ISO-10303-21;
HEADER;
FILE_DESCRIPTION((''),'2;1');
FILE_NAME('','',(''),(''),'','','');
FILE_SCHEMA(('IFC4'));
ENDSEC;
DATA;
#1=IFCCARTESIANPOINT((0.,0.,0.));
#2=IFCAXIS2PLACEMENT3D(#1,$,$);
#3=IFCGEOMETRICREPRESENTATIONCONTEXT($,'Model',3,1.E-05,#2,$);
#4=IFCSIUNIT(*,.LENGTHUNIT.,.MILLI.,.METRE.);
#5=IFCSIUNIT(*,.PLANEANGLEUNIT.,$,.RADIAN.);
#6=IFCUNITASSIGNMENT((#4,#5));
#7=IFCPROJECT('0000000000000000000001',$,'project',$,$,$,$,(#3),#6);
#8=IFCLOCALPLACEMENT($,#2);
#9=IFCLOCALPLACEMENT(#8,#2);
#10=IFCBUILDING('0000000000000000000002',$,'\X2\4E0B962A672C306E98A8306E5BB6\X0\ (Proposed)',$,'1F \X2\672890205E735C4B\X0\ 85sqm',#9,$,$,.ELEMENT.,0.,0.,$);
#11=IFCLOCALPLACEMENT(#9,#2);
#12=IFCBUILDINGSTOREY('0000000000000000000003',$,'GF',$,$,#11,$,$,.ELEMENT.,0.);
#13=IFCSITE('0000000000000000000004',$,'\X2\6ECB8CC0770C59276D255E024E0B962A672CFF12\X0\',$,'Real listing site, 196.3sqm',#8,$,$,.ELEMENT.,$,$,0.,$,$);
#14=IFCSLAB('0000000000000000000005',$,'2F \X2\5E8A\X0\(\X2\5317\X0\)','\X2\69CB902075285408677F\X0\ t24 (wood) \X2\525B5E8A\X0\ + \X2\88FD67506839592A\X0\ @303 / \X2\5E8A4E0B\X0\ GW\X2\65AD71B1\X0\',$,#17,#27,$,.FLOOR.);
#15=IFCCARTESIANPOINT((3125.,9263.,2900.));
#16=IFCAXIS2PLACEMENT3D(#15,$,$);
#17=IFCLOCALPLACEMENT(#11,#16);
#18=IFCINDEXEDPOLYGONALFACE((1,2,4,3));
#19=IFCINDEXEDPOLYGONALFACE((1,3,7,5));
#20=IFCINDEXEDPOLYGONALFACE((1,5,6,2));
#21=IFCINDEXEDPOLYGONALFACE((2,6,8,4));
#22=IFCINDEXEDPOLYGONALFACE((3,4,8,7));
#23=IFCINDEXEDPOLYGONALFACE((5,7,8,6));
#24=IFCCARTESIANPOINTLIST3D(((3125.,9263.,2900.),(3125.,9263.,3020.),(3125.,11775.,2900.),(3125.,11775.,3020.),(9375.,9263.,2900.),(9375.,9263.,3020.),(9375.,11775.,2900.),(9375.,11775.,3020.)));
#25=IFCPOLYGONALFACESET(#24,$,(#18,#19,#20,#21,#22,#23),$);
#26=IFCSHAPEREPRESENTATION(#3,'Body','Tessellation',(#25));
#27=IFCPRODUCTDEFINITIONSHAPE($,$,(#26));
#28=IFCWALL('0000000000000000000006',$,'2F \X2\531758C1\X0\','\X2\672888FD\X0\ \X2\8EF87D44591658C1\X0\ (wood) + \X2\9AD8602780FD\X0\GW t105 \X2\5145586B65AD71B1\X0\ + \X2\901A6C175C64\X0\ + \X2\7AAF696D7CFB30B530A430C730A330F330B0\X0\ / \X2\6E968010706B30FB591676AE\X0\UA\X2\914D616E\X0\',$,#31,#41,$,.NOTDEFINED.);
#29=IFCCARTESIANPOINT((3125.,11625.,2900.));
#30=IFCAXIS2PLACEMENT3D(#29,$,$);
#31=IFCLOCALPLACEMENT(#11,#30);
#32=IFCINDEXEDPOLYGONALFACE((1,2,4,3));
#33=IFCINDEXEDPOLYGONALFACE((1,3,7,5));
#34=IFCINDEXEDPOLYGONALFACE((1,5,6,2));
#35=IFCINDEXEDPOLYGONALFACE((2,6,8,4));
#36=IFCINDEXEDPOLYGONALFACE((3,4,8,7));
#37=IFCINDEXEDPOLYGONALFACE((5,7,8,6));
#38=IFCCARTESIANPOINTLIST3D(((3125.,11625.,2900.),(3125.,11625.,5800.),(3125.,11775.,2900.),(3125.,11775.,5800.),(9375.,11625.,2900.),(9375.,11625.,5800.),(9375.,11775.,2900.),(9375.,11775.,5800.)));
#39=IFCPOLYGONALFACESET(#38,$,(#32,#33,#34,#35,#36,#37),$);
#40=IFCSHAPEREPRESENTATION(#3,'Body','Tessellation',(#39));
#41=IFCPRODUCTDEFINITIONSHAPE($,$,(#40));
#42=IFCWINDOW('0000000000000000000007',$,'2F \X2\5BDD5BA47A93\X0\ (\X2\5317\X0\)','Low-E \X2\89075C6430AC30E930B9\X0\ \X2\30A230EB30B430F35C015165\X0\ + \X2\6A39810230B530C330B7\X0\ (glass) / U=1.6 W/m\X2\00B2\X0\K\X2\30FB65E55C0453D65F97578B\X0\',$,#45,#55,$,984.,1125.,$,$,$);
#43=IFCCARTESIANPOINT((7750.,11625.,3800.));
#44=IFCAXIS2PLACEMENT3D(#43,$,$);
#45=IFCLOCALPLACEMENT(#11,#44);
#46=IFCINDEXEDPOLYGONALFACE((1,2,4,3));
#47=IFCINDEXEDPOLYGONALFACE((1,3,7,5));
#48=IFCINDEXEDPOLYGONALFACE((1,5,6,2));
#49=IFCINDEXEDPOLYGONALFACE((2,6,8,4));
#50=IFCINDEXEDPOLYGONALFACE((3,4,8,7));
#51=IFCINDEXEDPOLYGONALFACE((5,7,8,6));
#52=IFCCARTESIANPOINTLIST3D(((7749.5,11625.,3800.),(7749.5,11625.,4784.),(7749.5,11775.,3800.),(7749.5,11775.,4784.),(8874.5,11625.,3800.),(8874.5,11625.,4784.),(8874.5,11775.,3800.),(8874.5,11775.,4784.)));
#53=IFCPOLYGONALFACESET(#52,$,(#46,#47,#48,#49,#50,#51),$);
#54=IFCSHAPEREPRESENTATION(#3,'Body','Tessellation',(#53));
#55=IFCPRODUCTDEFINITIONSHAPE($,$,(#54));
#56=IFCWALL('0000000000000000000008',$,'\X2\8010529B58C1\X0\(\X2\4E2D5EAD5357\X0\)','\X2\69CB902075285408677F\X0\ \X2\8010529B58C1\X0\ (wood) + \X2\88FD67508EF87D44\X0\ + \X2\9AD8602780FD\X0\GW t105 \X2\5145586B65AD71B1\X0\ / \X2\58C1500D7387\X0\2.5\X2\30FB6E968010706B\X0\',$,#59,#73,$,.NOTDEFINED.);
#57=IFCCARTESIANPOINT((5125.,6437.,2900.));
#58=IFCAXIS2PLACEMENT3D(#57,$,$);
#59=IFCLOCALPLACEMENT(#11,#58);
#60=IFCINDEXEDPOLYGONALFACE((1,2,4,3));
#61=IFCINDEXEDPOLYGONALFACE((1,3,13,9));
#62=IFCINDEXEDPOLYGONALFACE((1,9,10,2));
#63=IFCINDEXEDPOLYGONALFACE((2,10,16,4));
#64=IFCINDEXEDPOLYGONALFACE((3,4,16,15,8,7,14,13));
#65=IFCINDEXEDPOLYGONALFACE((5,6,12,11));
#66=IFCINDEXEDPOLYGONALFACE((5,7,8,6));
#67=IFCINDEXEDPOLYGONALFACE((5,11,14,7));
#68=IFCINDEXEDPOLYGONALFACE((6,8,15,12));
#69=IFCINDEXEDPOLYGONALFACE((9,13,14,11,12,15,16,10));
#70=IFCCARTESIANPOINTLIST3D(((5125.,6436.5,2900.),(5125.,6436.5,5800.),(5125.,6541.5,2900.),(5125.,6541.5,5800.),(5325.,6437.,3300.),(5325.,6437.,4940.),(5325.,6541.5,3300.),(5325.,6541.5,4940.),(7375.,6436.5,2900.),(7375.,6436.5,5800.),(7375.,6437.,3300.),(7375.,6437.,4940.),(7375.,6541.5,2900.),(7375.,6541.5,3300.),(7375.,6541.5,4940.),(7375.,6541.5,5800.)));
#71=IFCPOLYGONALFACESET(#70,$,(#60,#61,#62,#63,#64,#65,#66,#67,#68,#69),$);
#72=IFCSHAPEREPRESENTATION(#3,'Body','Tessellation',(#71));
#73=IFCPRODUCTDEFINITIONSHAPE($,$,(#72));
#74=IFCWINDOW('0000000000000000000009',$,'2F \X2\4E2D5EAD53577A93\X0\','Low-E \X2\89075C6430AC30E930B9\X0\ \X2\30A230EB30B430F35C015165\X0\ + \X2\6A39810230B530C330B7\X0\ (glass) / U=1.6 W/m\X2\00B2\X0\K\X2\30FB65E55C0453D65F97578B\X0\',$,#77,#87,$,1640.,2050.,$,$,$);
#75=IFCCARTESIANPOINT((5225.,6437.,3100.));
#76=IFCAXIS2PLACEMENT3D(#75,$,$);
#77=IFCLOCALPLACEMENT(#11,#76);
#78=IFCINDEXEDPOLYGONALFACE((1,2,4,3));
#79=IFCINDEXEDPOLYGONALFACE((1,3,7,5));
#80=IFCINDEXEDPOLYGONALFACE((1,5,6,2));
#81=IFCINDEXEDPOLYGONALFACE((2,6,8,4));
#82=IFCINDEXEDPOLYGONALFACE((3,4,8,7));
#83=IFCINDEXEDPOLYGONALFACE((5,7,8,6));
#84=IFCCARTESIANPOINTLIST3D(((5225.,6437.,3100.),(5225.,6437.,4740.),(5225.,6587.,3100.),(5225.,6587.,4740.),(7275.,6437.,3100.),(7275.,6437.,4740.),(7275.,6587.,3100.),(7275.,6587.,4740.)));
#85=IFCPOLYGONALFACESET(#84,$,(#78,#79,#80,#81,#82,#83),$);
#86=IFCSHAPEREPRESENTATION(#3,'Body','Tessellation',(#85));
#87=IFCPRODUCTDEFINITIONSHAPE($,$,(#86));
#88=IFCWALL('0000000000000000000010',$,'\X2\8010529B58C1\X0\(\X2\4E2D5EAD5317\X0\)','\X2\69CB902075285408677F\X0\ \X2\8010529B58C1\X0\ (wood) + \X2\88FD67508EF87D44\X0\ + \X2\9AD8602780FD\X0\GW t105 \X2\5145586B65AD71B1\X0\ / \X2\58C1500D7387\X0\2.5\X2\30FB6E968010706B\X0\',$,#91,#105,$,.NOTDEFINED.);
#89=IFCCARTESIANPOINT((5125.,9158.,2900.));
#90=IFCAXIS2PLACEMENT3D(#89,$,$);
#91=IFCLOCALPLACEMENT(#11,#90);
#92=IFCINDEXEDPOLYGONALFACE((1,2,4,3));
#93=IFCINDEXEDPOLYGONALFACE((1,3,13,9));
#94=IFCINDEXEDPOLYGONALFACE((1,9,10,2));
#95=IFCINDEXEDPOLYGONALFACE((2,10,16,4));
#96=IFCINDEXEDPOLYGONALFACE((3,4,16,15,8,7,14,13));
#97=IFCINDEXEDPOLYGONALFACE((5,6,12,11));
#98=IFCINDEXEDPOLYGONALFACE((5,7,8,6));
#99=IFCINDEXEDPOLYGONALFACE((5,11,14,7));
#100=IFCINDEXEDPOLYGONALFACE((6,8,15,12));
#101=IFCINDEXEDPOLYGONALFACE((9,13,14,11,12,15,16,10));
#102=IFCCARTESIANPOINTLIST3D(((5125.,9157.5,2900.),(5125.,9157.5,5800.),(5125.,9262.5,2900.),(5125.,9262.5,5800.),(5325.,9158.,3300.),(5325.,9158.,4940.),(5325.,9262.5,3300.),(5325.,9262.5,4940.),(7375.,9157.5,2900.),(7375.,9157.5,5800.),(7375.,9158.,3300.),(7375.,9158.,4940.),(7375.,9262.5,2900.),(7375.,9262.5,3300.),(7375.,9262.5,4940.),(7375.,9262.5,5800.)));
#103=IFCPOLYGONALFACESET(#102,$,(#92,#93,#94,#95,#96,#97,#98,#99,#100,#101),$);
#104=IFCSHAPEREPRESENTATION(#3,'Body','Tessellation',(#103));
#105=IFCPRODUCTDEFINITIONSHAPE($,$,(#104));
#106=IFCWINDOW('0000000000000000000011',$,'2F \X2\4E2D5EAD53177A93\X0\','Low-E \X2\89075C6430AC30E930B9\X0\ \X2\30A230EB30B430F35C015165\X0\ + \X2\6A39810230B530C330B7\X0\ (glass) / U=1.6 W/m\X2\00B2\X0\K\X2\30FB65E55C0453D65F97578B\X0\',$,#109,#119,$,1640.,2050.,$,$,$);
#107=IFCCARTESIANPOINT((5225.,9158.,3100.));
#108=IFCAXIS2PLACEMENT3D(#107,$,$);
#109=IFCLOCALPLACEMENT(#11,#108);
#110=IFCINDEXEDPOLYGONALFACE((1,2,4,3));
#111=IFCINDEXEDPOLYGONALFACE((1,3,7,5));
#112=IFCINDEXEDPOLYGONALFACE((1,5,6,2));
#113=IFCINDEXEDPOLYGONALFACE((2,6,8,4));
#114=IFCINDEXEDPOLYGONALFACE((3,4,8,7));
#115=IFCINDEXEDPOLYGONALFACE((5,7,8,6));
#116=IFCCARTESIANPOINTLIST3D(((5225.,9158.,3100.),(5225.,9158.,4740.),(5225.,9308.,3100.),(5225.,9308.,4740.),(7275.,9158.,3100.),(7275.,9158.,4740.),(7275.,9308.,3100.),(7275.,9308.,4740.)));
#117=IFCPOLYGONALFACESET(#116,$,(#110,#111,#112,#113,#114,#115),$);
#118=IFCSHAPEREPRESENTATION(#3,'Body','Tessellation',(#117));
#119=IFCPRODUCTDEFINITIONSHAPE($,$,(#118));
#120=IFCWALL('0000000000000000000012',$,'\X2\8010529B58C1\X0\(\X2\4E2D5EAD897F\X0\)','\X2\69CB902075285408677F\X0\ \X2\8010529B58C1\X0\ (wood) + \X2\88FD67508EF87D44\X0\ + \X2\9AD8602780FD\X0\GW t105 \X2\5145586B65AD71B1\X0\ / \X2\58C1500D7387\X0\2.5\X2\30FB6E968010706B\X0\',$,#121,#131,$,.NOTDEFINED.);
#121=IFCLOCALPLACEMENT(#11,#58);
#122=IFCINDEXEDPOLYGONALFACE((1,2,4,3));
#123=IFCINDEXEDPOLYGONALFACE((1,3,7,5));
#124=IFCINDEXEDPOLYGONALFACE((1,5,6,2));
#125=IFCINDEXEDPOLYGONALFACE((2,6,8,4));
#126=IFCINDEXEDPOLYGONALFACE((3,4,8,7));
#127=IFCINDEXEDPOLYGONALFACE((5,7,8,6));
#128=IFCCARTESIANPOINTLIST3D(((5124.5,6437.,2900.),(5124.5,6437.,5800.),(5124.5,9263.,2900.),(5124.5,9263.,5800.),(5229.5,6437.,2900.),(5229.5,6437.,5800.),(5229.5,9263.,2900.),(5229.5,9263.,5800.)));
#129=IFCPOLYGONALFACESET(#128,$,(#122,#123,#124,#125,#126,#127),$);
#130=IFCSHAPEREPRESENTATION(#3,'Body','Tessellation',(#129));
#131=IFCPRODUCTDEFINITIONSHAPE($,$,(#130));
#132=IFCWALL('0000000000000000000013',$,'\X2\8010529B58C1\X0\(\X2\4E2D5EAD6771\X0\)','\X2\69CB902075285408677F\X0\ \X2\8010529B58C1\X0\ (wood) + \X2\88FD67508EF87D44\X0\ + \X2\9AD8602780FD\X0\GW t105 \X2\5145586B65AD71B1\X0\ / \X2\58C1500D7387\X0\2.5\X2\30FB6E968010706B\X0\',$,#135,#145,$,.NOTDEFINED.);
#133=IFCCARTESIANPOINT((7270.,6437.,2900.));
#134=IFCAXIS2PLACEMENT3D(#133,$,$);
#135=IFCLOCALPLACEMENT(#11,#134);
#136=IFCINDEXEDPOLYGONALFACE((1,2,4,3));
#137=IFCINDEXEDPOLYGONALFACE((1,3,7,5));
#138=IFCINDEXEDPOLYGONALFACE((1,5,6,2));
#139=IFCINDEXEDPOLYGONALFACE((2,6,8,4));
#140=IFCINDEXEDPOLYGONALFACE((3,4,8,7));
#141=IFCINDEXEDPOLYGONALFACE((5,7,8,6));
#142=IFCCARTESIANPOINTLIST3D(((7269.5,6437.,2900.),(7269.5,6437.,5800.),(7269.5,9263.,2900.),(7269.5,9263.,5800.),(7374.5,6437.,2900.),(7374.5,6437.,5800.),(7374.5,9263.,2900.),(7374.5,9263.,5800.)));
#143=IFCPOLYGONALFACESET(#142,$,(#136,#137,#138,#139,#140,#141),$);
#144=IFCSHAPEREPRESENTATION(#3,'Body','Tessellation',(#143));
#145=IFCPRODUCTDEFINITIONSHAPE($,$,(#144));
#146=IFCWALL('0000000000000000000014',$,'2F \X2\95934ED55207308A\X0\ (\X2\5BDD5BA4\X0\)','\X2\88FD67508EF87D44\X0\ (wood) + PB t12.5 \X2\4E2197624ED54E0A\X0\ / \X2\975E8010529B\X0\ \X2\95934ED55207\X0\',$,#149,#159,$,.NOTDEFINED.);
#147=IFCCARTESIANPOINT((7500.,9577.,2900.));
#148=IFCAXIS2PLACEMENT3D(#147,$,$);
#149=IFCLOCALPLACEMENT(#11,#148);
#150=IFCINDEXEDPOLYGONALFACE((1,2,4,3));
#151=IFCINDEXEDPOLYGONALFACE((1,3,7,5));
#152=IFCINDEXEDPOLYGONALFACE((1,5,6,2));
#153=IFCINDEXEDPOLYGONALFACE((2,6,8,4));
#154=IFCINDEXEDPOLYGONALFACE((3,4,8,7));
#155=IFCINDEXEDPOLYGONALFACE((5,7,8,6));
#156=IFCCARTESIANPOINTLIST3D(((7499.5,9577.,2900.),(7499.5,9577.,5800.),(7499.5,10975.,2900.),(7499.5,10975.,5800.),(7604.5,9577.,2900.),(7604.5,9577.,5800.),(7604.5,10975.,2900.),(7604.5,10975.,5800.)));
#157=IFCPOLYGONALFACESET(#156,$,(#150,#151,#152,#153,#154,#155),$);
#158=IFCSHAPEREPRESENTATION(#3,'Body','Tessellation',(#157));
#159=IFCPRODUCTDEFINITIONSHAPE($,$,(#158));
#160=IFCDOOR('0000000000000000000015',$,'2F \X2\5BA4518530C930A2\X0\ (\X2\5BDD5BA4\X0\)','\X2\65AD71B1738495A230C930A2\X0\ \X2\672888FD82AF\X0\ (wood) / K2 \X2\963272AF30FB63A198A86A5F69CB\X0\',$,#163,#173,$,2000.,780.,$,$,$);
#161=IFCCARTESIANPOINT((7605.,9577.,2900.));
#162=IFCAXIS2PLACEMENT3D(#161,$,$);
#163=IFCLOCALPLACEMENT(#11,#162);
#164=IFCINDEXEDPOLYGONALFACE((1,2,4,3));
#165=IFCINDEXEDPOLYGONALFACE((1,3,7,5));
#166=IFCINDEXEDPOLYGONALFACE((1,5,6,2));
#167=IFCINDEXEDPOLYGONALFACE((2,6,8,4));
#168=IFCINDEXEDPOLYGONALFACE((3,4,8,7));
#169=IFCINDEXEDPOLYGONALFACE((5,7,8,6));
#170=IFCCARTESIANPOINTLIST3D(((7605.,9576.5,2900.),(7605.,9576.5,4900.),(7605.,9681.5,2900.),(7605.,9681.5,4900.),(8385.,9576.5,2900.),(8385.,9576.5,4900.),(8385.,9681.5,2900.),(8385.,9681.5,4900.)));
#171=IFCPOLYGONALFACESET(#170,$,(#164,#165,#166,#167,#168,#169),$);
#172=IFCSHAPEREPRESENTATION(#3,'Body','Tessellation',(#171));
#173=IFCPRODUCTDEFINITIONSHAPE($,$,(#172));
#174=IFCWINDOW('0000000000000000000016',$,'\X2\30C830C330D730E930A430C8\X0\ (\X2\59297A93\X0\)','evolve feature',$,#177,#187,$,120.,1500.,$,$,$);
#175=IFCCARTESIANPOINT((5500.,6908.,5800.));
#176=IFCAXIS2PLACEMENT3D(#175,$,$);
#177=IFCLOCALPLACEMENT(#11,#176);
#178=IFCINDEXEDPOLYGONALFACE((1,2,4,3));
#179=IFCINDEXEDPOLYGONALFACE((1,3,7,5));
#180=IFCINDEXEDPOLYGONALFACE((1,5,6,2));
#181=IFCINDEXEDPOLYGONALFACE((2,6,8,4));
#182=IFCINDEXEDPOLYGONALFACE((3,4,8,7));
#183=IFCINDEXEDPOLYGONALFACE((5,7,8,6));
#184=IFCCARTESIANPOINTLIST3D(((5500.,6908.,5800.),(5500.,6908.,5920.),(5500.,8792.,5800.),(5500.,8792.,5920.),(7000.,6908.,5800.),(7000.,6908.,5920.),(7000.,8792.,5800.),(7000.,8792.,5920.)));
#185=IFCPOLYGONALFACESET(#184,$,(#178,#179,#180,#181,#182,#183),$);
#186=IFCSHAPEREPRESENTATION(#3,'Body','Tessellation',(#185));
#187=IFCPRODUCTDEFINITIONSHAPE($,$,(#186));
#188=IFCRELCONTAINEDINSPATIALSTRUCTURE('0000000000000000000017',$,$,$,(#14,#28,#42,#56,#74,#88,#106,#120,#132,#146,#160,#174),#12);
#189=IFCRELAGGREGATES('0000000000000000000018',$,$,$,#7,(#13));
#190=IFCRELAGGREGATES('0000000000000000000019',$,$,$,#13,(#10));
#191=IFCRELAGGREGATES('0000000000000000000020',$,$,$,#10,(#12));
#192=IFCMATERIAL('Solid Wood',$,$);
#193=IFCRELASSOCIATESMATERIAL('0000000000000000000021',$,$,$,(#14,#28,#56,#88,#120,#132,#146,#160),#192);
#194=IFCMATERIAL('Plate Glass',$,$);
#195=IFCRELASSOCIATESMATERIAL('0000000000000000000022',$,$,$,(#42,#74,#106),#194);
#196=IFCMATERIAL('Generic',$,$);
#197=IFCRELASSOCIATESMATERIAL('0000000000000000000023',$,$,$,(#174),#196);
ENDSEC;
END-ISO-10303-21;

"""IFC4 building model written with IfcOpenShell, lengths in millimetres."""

from ifc_helpers import new_model, si_unit, frame, frame_2d, origin, place, context, project, spatial, rectangle, extrude, material, element, fill, save


model = new_model("IFC4")

# Units and contexts
model_context = context("Model", 3, precision=1e-05, world=origin())
ifc_project = project(units=[si_unit("LENGTHUNIT", "METRE", prefix="MILLI"), si_unit("PLANEANGLEUNIT", "RADIAN")], contexts=[model_context])

# Site, building, storey
site_placement = place(None, origin())
site = spatial("IfcSite", under=ifc_project, at=site_placement, Name="滋賀県大津市下阪本２", ObjectType="Real listing site, 196.3sqm", CompositionType="ELEMENT", RefElevation=0.0)
building_placement = place(site_placement, origin())
building = spatial("IfcBuilding", under=site, at=building_placement, Name="下阪本の風の家 (Proposed)", ObjectType="1F 木造平屋 85sqm", CompositionType="ELEMENT", ElevationOfRefHeight=0.0, ElevationOfTerrain=0.0)
storey_placement = place(building_placement, origin())
storey = spatial("IfcBuildingStorey", under=building, at=storey_placement, Name="GF", CompositionType="ELEMENT", Elevation=0.0)

# Slab
ifc_material_1 = material(Name="Solid Wood")
slab_placement = place(storey_placement, frame((3125.0, 9263.0, 2900.0)))
element("IfcSlab", 1, at=slab_placement, inside=storey, material=ifc_material_1, Name="2F 床(北)", Description="構造用合板 t24 (wood) 剛床 + 製材根太 @303 / 床下 GW断熱", PredefinedType="FLOOR", context=model_context, shape_type="SweptSolid", body=[
    extrude(rectangle(XDim=6250.0, YDim=2512.0, at=frame_2d((3125.0, 1256.0))), frame((3125.0, 9263.0, 2900.0)), (0.0, 0.0, 1.0), 120.0),
])

# Walls, openings, windows
wall_1_placement = place(storey_placement, frame((3125.0, 11625.0, 2900.0)))
wall_1 = element("IfcWall", 2, at=wall_1_placement, inside=storey, material=ifc_material_1, Name="2F 北壁", Description="木製 軸組外壁 (wood) + 高性能GW t105 充填断熱 + 通気層 + 窯業系サイディング / 準耐火・外皮UA配慮", PredefinedType="NOTDEFINED", context=model_context, shape_type="SweptSolid", body=[
    extrude(rectangle(XDim=6250.0, YDim=150.0, at=frame_2d((3125.0, 75.0))), frame((3125.0, 11625.0, 2900.0)), (0.0, 0.0, 1.0), 2900.0),
])
opening_1_placement = place(storey_placement, frame((7750.0, 11625.0, 3800.0)))
opening_1 = element("IfcOpeningElement", 3, at=opening_1_placement, cuts=wall_1, PredefinedType="NOTDEFINED", context=model_context, shape_type="SweptSolid", body=[
    extrude(rectangle(XDim=1125.0, YDim=150.0, at=frame_2d((562.0, 75.0))), frame((7750.0, 11625.0, 3800.0)), (0.0, 0.0, 1.0), 984.0),
])
ifc_material_2 = material(Name="Plate Glass")
window_1_placement = place(storey_placement, frame((7750.0, 11625.0, 3800.0)))
window_1 = element("IfcWindow", 4, at=window_1_placement, inside=storey, material=ifc_material_2, Name="2F 寝室窓 (北)", Description="Low-E 複層ガラス アルゴン封入 + 樹脂サッシ (glass) / U=1.6 W/m²K・日射取得型", OverallHeight=984.0, OverallWidth=1125.0, context=model_context, shape_type="SweptSolid", body=[
    extrude(rectangle(XDim=1125.0, YDim=150.0, at=frame_2d((562.0, 75.0))), frame((7750.0, 11625.0, 3800.0)), (0.0, 0.0, 1.0), 984.0),
])
fill(opening_1, window_1)
wall_2_placement = place(storey_placement, frame((5125.0, 6437.0, 2900.0)))
wall_2 = element("IfcWall", 5, at=wall_2_placement, inside=storey, material=ifc_material_1, Name="耐力壁(中庭南)", Description="構造用合板 耐力壁 (wood) + 製材軸組 + 高性能GW t105 充填断熱 / 壁倍率2.5・準耐火", PredefinedType="NOTDEFINED", context=model_context, shape_type="SweptSolid", body=[
    extrude(rectangle(XDim=2250.0, YDim=105.0, at=frame_2d((1125.0, 52.0))), frame((5125.0, 6437.0, 2900.0)), (0.0, 0.0, 1.0), 2900.0),
])
opening_2_placement = place(storey_placement, frame((5225.0, 6437.0, 3100.0)))
opening_2 = element("IfcOpeningElement", 6, at=opening_2_placement, cuts=wall_2, PredefinedType="NOTDEFINED", context=model_context, shape_type="SweptSolid", body=[
    extrude(rectangle(XDim=2050.0, YDim=150.0, at=frame_2d((1025.0, 75.0))), frame((5225.0, 6437.0, 3100.0)), (0.0, 0.0, 1.0), 1640.0),
])
window_2_placement = place(storey_placement, frame((5225.0, 6437.0, 3100.0)))
window_2 = element("IfcWindow", 7, at=window_2_placement, inside=storey, material=ifc_material_2, Name="2F 中庭南窓", Description="Low-E 複層ガラス アルゴン封入 + 樹脂サッシ (glass) / U=1.6 W/m²K・日射取得型", OverallHeight=1640.0, OverallWidth=2050.0, context=model_context, shape_type="SweptSolid", body=[
    extrude(rectangle(XDim=2050.0, YDim=150.0, at=frame_2d((1025.0, 75.0))), frame((5225.0, 6437.0, 3100.0)), (0.0, 0.0, 1.0), 1640.0),
])
fill(opening_2, window_2)
wall_3_placement = place(storey_placement, frame((5125.0, 9158.0, 2900.0)))
wall_3 = element("IfcWall", 8, at=wall_3_placement, inside=storey, material=ifc_material_1, Name="耐力壁(中庭北)", Description="構造用合板 耐力壁 (wood) + 製材軸組 + 高性能GW t105 充填断熱 / 壁倍率2.5・準耐火", PredefinedType="NOTDEFINED", context=model_context, shape_type="SweptSolid", body=[
    extrude(rectangle(XDim=2250.0, YDim=105.0, at=frame_2d((1125.0, 52.0))), frame((5125.0, 9158.0, 2900.0)), (0.0, 0.0, 1.0), 2900.0),
])
opening_3_placement = place(storey_placement, frame((5225.0, 9158.0, 3100.0)))
opening_3 = element("IfcOpeningElement", 9, at=opening_3_placement, cuts=wall_3, PredefinedType="NOTDEFINED", context=model_context, shape_type="SweptSolid", body=[
    extrude(rectangle(XDim=2050.0, YDim=150.0, at=frame_2d((1025.0, 75.0))), frame((5225.0, 9158.0, 3100.0)), (0.0, 0.0, 1.0), 1640.0),
])
window_3_placement = place(storey_placement, frame((5225.0, 9158.0, 3100.0)))
window_3 = element("IfcWindow", 10, at=window_3_placement, inside=storey, material=ifc_material_2, Name="2F 中庭北窓", Description="Low-E 複層ガラス アルゴン封入 + 樹脂サッシ (glass) / U=1.6 W/m²K・日射取得型", OverallHeight=1640.0, OverallWidth=2050.0, context=model_context, shape_type="SweptSolid", body=[
    extrude(rectangle(XDim=2050.0, YDim=150.0, at=frame_2d((1025.0, 75.0))), frame((5225.0, 9158.0, 3100.0)), (0.0, 0.0, 1.0), 1640.0),
])
fill(opening_3, window_3)

# Walls
wall_4_placement = place(storey_placement, frame((5125.0, 6437.0, 2900.0)))
element("IfcWall", 11, at=wall_4_placement, inside=storey, material=ifc_material_1, Name="耐力壁(中庭西)", Description="構造用合板 耐力壁 (wood) + 製材軸組 + 高性能GW t105 充填断熱 / 壁倍率2.5・準耐火", PredefinedType="NOTDEFINED", context=model_context, shape_type="SweptSolid", body=[
    extrude(rectangle(XDim=105.0, YDim=2826.0, at=frame_2d((52.0, 1413.0))), frame((5125.0, 6437.0, 2900.0)), (0.0, 0.0, 1.0), 2900.0),
])
wall_5_placement = place(storey_placement, frame((7270.0, 6437.0, 2900.0)))
element("IfcWall", 12, at=wall_5_placement, inside=storey, material=ifc_material_1, Name="耐力壁(中庭東)", Description="構造用合板 耐力壁 (wood) + 製材軸組 + 高性能GW t105 充填断熱 / 壁倍率2.5・準耐火", PredefinedType="NOTDEFINED", context=model_context, shape_type="SweptSolid", body=[
    extrude(rectangle(XDim=105.0, YDim=2826.0, at=frame_2d((52.0, 1413.0))), frame((7270.0, 6437.0, 2900.0)), (0.0, 0.0, 1.0), 2900.0),
])
wall_6_placement = place(storey_placement, frame((7500.0, 9577.0, 2900.0)))
element("IfcWall", 13, at=wall_6_placement, inside=storey, material=ifc_material_1, Name="2F 間仕切り (寝室)", Description="製材軸組 (wood) + PB t12.5 両面仕上 / 非耐力 間仕切", PredefinedType="NOTDEFINED", context=model_context, shape_type="SweptSolid", body=[
    extrude(rectangle(XDim=105.0, YDim=1398.0, at=frame_2d((52.0, 699.0))), frame((7500.0, 9577.0, 2900.0)), (0.0, 0.0, 1.0), 2900.0),
])

# Door
door_placement = place(storey_placement, frame((7605.0, 9577.0, 2900.0)))
element("IfcDoor", 14, at=door_placement, inside=storey, material=ifc_material_1, Name="2F 室内ドア (寝室)", Description="断熱玄関ドア 木製芯 (wood) / K2 防犯・採風機構", OverallHeight=2000.0, OverallWidth=780.0, context=model_context, shape_type="SweptSolid", body=[
    extrude(rectangle(XDim=780.0, YDim=105.0, at=frame_2d((390.0, 52.0))), frame((7605.0, 9577.0, 2900.0)), (0.0, 0.0, 1.0), 2000.0),
])

# Window
ifc_material_3 = material(Name="Generic")
window_4_placement = place(storey_placement, frame((5500.0, 6908.0, 5800.0)))
element("IfcWindow", 15, at=window_4_placement, inside=storey, material=ifc_material_3, Name="トップライト (天窓)", Description="evolve feature", OverallHeight=120.0, OverallWidth=1500.0, context=model_context, shape_type="SweptSolid", body=[
    extrude(rectangle(XDim=1500.0, YDim=1884.0, at=frame_2d((750.0, 942.0))), frame((5500.0, 6908.0, 5800.0)), (0.0, 0.0, 1.0), 120.0),
])

save(model, "model.ifc")
